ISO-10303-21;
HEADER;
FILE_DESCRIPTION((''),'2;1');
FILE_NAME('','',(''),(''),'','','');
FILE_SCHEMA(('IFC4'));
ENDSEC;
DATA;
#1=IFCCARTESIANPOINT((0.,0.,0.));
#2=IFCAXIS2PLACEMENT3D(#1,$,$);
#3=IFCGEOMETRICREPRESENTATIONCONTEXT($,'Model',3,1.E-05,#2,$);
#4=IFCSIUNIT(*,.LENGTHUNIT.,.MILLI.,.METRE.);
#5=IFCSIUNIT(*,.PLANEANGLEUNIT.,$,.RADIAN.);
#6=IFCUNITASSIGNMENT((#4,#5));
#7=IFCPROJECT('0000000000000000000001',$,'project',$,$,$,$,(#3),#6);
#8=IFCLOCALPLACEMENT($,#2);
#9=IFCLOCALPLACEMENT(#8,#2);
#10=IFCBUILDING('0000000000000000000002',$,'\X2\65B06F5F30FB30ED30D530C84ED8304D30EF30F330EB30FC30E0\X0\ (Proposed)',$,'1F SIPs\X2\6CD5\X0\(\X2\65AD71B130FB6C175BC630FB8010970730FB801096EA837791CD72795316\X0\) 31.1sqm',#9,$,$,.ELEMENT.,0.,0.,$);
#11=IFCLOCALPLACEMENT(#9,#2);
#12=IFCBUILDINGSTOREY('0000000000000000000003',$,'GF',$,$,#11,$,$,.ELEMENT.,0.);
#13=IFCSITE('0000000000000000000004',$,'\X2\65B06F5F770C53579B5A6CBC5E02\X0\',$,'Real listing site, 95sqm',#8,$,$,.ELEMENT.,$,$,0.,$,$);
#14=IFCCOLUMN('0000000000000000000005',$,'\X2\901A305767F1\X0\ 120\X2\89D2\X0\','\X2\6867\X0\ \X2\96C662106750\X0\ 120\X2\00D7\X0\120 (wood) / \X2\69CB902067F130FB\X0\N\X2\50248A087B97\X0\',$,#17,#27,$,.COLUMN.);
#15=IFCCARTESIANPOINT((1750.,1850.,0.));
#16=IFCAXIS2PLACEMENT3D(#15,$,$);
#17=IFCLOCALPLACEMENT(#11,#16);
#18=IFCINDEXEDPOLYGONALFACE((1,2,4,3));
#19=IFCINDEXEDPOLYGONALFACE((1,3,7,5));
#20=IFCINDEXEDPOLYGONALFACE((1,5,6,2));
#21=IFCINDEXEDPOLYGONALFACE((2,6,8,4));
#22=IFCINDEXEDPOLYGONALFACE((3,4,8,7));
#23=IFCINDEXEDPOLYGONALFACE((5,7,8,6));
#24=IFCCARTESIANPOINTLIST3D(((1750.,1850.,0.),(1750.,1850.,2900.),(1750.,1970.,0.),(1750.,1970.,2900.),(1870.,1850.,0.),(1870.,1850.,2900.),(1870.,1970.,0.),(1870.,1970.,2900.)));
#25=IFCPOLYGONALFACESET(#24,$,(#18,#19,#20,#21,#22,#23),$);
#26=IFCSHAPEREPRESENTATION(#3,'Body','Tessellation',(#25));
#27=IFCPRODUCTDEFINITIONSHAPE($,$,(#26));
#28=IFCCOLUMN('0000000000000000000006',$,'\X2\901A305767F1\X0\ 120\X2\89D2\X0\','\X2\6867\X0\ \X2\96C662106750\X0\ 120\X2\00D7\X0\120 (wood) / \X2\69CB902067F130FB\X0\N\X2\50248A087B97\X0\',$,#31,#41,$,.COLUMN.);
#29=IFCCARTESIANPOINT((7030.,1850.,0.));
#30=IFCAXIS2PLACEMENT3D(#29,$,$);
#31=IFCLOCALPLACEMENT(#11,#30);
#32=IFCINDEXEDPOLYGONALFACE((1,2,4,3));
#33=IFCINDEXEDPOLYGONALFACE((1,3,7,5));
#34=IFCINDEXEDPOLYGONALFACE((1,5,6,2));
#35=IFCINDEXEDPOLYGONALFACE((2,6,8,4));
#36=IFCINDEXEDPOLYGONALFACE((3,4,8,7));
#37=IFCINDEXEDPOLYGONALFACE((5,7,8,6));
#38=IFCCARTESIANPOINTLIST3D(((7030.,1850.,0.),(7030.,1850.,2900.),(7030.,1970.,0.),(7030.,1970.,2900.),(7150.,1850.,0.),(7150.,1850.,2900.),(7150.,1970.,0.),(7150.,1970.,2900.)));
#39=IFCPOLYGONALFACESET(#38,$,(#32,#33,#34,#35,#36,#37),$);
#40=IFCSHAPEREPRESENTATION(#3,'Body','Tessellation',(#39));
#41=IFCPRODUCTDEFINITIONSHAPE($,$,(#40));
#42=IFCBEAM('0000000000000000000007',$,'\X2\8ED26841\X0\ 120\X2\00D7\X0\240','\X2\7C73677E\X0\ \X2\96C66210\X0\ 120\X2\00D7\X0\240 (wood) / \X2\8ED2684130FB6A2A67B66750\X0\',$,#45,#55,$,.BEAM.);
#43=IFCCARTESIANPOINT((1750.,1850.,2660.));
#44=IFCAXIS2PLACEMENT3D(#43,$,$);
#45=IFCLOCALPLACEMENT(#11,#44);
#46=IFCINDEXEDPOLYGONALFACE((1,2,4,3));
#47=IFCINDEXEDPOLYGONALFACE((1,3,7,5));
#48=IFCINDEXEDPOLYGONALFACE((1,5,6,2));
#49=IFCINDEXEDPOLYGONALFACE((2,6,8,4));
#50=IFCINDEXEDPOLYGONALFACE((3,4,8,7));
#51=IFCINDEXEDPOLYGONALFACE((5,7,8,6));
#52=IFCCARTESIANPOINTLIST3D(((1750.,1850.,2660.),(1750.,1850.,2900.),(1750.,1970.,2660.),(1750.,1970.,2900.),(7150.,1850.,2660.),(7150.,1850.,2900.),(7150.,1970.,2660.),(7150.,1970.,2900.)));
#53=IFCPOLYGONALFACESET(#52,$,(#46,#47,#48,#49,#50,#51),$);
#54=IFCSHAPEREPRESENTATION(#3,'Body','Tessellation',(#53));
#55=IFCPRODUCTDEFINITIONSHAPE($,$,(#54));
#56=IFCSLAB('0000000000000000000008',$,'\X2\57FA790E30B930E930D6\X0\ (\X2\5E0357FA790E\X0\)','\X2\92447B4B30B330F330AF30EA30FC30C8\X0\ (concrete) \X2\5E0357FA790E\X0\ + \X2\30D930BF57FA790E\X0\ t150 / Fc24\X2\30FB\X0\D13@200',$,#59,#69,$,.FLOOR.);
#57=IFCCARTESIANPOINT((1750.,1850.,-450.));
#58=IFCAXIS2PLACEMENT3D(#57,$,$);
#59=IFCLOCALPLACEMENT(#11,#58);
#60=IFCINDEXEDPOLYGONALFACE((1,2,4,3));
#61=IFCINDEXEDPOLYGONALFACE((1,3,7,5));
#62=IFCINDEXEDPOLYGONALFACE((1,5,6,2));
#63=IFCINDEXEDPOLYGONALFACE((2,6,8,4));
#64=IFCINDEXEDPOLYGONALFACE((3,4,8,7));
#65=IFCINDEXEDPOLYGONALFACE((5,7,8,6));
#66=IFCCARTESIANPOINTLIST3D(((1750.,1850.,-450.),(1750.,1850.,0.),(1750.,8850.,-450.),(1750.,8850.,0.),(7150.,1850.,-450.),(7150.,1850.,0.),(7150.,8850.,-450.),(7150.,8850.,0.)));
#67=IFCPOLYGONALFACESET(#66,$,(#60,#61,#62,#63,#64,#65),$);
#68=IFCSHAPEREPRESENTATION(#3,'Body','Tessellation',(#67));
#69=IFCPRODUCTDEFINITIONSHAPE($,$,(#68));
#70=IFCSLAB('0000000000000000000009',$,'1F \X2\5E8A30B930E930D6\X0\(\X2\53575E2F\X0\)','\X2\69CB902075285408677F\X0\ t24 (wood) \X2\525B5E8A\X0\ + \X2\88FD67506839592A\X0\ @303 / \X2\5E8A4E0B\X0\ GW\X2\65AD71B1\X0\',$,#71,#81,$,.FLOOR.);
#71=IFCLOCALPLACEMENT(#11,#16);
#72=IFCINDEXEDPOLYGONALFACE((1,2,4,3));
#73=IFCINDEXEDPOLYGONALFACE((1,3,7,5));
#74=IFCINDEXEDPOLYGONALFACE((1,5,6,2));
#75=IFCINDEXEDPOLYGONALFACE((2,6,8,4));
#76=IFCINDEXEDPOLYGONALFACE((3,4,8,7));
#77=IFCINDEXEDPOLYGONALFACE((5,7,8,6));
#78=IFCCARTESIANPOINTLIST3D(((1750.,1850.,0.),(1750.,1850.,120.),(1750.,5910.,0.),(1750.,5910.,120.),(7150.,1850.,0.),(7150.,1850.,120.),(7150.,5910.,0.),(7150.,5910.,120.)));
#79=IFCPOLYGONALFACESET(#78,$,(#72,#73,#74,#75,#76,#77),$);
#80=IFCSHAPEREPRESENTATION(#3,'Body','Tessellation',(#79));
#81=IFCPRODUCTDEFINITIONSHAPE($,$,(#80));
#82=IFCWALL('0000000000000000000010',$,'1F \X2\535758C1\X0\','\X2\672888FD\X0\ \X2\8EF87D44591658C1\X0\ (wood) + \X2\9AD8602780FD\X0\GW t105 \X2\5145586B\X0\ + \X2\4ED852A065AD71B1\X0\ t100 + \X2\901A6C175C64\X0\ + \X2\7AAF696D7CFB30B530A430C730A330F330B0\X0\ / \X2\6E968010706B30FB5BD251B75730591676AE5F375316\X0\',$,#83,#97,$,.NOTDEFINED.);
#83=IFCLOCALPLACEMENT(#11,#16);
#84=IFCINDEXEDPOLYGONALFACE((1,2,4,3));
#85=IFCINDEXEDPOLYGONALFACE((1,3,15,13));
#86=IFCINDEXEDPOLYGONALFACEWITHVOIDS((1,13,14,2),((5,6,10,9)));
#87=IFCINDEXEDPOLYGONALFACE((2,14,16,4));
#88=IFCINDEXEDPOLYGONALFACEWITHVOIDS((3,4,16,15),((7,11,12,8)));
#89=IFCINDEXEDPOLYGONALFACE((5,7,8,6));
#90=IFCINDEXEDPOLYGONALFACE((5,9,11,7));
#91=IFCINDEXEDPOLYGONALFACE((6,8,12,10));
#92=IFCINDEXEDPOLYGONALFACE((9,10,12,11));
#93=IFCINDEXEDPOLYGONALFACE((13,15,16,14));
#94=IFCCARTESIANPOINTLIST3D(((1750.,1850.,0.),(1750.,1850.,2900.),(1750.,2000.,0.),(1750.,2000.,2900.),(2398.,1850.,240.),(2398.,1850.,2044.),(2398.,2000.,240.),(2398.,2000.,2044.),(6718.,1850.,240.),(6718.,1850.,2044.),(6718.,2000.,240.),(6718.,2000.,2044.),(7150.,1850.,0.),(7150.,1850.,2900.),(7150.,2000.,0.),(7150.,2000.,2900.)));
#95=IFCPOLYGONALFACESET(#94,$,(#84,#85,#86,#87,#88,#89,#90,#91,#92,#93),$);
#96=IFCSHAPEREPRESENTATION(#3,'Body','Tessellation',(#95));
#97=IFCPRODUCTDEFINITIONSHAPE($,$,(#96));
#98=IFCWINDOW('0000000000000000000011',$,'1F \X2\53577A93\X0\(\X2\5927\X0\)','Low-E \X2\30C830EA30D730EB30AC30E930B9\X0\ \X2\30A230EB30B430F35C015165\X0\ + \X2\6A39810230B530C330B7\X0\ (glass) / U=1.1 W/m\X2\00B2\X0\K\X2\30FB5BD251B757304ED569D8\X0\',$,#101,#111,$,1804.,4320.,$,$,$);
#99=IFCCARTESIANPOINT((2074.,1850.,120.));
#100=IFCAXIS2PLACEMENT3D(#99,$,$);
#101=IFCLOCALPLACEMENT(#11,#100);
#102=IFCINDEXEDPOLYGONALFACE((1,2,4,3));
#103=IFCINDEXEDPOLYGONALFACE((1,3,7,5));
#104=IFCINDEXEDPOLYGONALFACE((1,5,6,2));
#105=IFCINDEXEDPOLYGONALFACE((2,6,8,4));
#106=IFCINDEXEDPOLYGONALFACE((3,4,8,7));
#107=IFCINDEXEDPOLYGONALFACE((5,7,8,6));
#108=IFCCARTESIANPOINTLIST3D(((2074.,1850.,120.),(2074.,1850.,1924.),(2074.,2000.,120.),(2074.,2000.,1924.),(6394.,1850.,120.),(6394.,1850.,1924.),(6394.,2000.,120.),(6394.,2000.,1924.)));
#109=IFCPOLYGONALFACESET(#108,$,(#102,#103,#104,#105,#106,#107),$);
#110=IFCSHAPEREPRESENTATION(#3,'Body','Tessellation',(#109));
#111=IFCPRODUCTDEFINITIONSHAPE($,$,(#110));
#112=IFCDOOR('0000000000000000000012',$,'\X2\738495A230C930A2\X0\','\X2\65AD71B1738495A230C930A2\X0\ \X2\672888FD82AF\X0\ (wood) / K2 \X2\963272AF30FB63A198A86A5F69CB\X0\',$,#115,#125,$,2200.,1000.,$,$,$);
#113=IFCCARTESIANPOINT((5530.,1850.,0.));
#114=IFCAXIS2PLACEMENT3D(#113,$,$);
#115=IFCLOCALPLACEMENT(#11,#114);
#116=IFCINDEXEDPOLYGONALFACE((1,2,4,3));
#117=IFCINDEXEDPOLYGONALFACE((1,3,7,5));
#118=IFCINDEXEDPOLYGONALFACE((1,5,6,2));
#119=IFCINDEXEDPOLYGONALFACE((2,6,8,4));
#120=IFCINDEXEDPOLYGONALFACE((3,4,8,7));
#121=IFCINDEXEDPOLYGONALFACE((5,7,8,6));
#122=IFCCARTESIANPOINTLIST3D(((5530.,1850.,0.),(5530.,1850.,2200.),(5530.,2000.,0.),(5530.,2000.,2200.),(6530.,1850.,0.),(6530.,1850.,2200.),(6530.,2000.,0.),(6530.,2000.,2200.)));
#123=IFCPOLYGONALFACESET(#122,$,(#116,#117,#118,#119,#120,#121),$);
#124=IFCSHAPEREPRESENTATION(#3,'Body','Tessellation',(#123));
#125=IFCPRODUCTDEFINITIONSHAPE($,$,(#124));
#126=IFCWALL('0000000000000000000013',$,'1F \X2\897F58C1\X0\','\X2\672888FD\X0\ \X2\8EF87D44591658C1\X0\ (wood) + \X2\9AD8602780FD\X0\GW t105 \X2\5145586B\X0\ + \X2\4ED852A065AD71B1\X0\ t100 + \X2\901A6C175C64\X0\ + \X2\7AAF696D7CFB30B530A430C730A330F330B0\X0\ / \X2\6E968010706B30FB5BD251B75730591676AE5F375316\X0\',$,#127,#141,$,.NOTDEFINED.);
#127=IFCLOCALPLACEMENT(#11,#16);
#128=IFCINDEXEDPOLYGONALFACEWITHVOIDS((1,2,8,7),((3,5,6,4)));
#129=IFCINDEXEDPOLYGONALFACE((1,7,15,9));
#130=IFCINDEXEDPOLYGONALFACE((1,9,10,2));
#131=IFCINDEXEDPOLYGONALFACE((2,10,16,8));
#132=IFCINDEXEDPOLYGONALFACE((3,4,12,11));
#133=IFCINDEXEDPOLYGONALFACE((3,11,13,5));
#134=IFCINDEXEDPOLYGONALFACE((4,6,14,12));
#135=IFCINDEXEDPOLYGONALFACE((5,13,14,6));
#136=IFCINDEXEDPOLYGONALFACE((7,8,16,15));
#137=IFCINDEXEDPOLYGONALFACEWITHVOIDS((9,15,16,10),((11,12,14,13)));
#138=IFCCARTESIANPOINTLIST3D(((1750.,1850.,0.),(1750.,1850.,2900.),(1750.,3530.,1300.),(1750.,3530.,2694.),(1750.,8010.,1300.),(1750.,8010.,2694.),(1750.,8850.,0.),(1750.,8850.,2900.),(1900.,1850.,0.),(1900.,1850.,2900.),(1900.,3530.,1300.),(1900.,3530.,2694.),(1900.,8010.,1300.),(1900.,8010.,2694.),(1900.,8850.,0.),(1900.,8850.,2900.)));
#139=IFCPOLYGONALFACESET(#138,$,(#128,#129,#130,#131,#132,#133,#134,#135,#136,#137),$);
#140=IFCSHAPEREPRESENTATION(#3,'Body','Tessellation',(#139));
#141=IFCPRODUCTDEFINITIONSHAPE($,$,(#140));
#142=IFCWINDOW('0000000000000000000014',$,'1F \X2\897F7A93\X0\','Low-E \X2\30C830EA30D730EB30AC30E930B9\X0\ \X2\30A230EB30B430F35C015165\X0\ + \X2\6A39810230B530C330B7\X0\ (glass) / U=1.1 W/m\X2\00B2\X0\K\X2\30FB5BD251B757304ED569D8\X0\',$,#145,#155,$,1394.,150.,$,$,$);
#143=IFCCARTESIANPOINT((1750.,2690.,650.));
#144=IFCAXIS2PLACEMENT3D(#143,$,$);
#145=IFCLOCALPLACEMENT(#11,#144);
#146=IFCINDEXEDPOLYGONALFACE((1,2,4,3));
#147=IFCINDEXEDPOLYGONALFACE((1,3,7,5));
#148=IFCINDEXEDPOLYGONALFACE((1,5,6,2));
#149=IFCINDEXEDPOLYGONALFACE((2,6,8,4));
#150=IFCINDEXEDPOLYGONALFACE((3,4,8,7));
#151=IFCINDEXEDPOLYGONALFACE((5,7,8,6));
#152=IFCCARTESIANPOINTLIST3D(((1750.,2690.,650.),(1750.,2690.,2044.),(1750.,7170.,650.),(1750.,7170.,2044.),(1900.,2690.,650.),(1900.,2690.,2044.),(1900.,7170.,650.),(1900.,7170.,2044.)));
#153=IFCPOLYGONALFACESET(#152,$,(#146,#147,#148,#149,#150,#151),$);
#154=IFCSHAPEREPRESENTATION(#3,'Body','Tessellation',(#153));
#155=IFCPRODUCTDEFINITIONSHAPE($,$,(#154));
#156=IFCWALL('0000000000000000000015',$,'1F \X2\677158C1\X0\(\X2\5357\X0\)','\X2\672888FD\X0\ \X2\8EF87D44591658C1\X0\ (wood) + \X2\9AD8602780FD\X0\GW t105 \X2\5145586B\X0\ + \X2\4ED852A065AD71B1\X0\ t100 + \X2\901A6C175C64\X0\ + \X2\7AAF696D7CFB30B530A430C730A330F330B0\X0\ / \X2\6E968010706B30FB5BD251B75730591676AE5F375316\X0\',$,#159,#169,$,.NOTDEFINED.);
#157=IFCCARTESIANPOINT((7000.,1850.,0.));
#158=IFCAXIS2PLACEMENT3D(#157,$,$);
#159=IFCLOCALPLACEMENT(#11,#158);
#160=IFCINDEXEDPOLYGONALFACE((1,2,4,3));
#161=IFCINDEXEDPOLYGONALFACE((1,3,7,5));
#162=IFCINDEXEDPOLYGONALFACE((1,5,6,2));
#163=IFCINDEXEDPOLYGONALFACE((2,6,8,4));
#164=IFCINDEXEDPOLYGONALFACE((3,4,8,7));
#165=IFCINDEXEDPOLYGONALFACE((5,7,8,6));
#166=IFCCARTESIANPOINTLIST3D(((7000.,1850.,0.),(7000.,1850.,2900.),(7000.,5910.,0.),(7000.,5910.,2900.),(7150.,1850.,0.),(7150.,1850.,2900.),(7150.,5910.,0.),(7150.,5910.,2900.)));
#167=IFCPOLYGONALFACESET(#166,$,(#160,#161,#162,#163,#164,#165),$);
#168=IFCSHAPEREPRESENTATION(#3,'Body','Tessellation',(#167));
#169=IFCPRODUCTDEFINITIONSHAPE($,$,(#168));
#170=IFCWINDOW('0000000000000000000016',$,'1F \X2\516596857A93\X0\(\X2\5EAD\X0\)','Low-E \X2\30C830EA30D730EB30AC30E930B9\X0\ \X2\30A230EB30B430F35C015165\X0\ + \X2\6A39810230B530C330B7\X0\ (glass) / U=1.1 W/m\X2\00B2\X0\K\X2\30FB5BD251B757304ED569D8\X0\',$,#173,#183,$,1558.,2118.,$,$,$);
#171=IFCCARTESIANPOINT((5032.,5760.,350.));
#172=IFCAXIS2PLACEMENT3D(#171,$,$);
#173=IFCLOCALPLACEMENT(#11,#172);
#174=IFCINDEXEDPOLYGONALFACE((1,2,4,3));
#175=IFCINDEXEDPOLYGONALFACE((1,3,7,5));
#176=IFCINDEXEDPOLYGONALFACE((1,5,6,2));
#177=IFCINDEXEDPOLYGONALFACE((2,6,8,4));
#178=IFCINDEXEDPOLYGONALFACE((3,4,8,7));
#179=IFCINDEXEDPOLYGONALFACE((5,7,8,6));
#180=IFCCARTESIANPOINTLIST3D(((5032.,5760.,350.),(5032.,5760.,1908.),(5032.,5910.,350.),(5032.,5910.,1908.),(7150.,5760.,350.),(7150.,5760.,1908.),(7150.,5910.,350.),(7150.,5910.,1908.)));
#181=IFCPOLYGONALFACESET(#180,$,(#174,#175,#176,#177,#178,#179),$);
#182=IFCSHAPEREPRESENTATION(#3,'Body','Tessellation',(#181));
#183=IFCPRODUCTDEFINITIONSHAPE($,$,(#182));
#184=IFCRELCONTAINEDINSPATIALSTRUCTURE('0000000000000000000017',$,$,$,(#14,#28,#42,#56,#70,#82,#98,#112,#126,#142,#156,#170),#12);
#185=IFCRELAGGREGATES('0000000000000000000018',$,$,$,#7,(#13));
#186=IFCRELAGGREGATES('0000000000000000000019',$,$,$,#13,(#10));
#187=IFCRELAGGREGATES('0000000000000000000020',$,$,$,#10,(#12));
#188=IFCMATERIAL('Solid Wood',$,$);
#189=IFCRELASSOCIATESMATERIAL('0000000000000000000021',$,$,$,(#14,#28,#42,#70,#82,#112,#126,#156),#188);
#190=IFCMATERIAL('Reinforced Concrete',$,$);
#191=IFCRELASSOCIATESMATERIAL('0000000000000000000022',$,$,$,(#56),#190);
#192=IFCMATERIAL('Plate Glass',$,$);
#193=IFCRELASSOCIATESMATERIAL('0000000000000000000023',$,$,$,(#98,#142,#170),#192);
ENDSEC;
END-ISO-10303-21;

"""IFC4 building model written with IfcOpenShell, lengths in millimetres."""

from ifc_helpers import new_model, si_unit, frame, frame_2d, origin, place, context, project, spatial, rectangle, extrude, material, element, fill, save


model = new_model("IFC4")

# Units and contexts
model_context = context("Model", 3, precision=1e-05, world=origin())
ifc_project = project(units=[si_unit("LENGTHUNIT", "METRE", prefix="MILLI"), si_unit("PLANEANGLEUNIT", "RADIAN")], contexts=[model_context])

# Site, building, storey
site_placement = place(None, origin())
site = spatial("IfcSite", under=ifc_project, at=site_placement, Name="新潟県南魚沼市", ObjectType="Real listing site, 95sqm", CompositionType="ELEMENT", RefElevation=0.0)
building_placement = place(site_placement, origin())
building = spatial("IfcBuilding", under=site, at=building_placement, Name="新潟・ロフト付きワンルーム (Proposed)", ObjectType="1F SIPs法(断熱・気密・耐震・耐雪荷重特化) 31.1sqm", CompositionType="ELEMENT", ElevationOfRefHeight=0.0, ElevationOfTerrain=0.0)
storey_placement = place(building_placement, origin())
storey = spatial("IfcBuildingStorey", under=building, at=storey_placement, Name="GF", CompositionType="ELEMENT", Elevation=0.0)

# Columns
ifc_material_1 = material(Name="Solid Wood")
column_1_placement = place(storey_placement, frame((1750.0, 1850.0, 0.0)))
element("IfcColumn", 1, at=column_1_placement, inside=storey, material=ifc_material_1, Name="通し柱 120角", Description="桧 集成材 120×120 (wood) / 構造柱・N値計算", PredefinedType="COLUMN", context=model_context, shape_type="SweptSolid", body=[
    extrude(rectangle(XDim=120.0, YDim=120.0, at=frame_2d((60.0, 60.0))), frame((1750.0, 1850.0, 0.0)), (0.0, 0.0, 1.0), 2900.0),
])
column_2_placement = place(storey_placement, frame((7030.0, 1850.0, 0.0)))
element("IfcColumn", 2, at=column_2_placement, inside=storey, material=ifc_material_1, Name="通し柱 120角", Description="桧 集成材 120×120 (wood) / 構造柱・N値計算", PredefinedType="COLUMN", context=model_context, shape_type="SweptSolid", body=[
    extrude(rectangle(XDim=120.0, YDim=120.0, at=frame_2d((60.0, 60.0))), frame((7030.0, 1850.0, 0.0)), (0.0, 0.0, 1.0), 2900.0),
])

# Beam
beam_1_placement = place(storey_placement, frame((1750.0, 1850.0, 2660.0)))
element("IfcBeam", 3, at=beam_1_placement, inside=storey, material=ifc_material_1, Name="軒桁 120×240", Description="米松 集成 120×240 (wood) / 軒桁・横架材", PredefinedType="BEAM", context=model_context, shape_type="SweptSolid", body=[
    extrude(rectangle(XDim=5400.0, YDim=120.0, at=frame_2d((2700.0, 60.0))), frame((1750.0, 1850.0, 2660.0)), (0.0, 0.0, 1.0), 240.0),
])

# Slabs
ifc_material_2 = material(Name="Reinforced Concrete")
slab_1_placement = place(storey_placement, frame((1750.0, 1850.0, -450.0)))
element("IfcSlab", 4, at=slab_1_placement, inside=storey, material=ifc_material_2, Name="基礎スラブ (布基礎)", Description="鉄筋コンクリート (concrete) 布基礎 + ベタ基礎 t150 / Fc24・D13@200", PredefinedType="FLOOR", context=model_context, shape_type="SweptSolid", body=[
    extrude(rectangle(XDim=5400.0, YDim=7000.0, at=frame_2d((2700.0, 3500.0))), frame((1750.0, 1850.0, -450.0)), (0.0, 0.0, 1.0), 450.0),
])
slab_2_placement = place(storey_placement, frame((1750.0, 1850.0, 0.0)))
element("IfcSlab", 5, at=slab_2_placement, inside=storey, material=ifc_material_1, Name="1F 床スラブ(南帯)", Description="構造用合板 t24 (wood) 剛床 + 製材根太 @303 / 床下 GW断熱", PredefinedType="FLOOR", context=model_context, shape_type="SweptSolid", body=[
    extrude(rectangle(XDim=5400.0, YDim=4060.0, at=frame_2d((2700.0, 2030.0))), frame((1750.0, 1850.0, 0.0)), (0.0, 0.0, 1.0), 120.0),
])

# Wall, openings, window, door
wall_1_placement = place(storey_placement, frame((1750.0, 1850.0, 0.0)))
wall_1 = element("IfcWall", 6, at=wall_1_placement, inside=storey, material=ifc_material_1, Name="1F 南壁", Description="木製 軸組外壁 (wood) + 高性能GW t105 充填 + 付加断熱 t100 + 通気層 + 窯業系サイディング / 準耐火・寒冷地外皮強化", PredefinedType="NOTDEFINED", context=model_context, shape_type="SweptSolid", body=[
    extrude(rectangle(XDim=5400.0, YDim=150.0, at=frame_2d((2700.0, 75.0))), frame((1750.0, 1850.0, 0.0)), (0.0, 0.0, 1.0), 2900.0),
])
opening_1_placement = place(storey_placement, frame((2074.0, 1850.0, 120.0)))
opening_1 = element("IfcOpeningElement", 7, at=opening_1_placement, cuts=wall_1, PredefinedType="NOTDEFINED", context=model_context, shape_type="SweptSolid", body=[
    extrude(rectangle(XDim=4320.0, YDim=150.0, at=frame_2d((2160.0, 75.0))), frame((2074.0, 1850.0, 120.0)), (0.0, 0.0, 1.0), 1804.0),
])
opening_2_placement = place(storey_placement, frame((5530.0, 1850.0, 0.0)))
opening_2 = element("IfcOpeningElement", 8, at=opening_2_placement, cuts=wall_1, PredefinedType="NOTDEFINED", context=model_context, shape_type="SweptSolid", body=[
    extrude(rectangle(XDim=1000.0, YDim=150.0, at=frame_2d((500.0, 75.0))), frame((5530.0, 1850.0, 0.0)), (0.0, 0.0, 1.0), 2200.0),
])
ifc_material_3 = material(Name="Plate Glass")
window_1_placement = place(storey_placement, frame((2074.0, 1850.0, 120.0)))
window_1 = element("IfcWindow", 9, at=window_1_placement, inside=storey, material=ifc_material_3, Name="1F 南窓(大)", Description="Low-E トリプルガラス アルゴン封入 + 樹脂サッシ (glass) / U=1.1 W/m²K・寒冷地仕様", OverallHeight=1804.0, OverallWidth=4320.0, context=model_context, shape_type="SweptSolid", body=[
    extrude(rectangle(XDim=4320.0, YDim=150.0, at=frame_2d((2160.0, 75.0))), frame((2074.0, 1850.0, 120.0)), (0.0, 0.0, 1.0), 1804.0),
])
fill(opening_1, window_1)
door_1_placement = place(storey_placement, frame((5530.0, 1850.0, 0.0)))
door_1 = element("IfcDoor", 10, at=door_1_placement, inside=storey, material=ifc_material_1, Name="玄関ドア", Description="断熱玄関ドア 木製芯 (wood) / K2 防犯・採風機構", OverallHeight=2200.0, OverallWidth=1000.0, context=model_context, shape_type="SweptSolid", body=[
    extrude(rectangle(XDim=1000.0, YDim=150.0, at=frame_2d((500.0, 75.0))), frame((5530.0, 1850.0, 0.0)), (0.0, 0.0, 1.0), 2200.0),
])
fill(opening_2, door_1)

# Walls, openings, windows
wall_2_placement = place(storey_placement, frame((1750.0, 1850.0, 0.0)))
wall_2 = element("IfcWall", 11, at=wall_2_placement, inside=storey, material=ifc_material_1, Name="1F 西壁", Description="木製 軸組外壁 (wood) + 高性能GW t105 充填 + 付加断熱 t100 + 通気層 + 窯業系サイディング / 準耐火・寒冷地外皮強化", PredefinedType="NOTDEFINED", context=model_context, shape_type="SweptSolid", body=[
    extrude(rectangle(XDim=150.0, YDim=7000.0, at=frame_2d((75.0, 3500.0))), frame((1750.0, 1850.0, 0.0)), (0.0, 0.0, 1.0), 2900.0),
])
opening_3_placement = place(storey_placement, frame((1750.0, 2690.0, 650.0)))
opening_3 = element("IfcOpeningElement", 12, at=opening_3_placement, cuts=wall_2, PredefinedType="NOTDEFINED", context=model_context, shape_type="SweptSolid", body=[
    extrude(rectangle(XDim=150.0, YDim=4480.0, at=frame_2d((75.0, 2240.0))), frame((1750.0, 2690.0, 650.0)), (0.0, 0.0, 1.0), 1394.0),
])
window_2_placement = place(storey_placement, frame((1750.0, 2690.0, 650.0)))
window_2 = element("IfcWindow", 13, at=window_2_placement, inside=storey, material=ifc_material_3, Name="1F 西窓", Description="Low-E トリプルガラス アルゴン封入 + 樹脂サッシ (glass) / U=1.1 W/m²K・寒冷地仕様", OverallHeight=1394.0, OverallWidth=150.0, context=model_context, shape_type="SweptSolid", body=[
    extrude(rectangle(XDim=150.0, YDim=4480.0, at=frame_2d((75.0, 2240.0))), frame((1750.0, 2690.0, 650.0)), (0.0, 0.0, 1.0), 1394.0),
])
fill(opening_3, window_2)
wall_3_placement = place(storey_placement, frame((7000.0, 1850.0, 0.0)))
wall_3 = element("IfcWall", 14, at=wall_3_placement, inside=storey, material=ifc_material_1, Name="1F 東壁(南)", Description="木製 軸組外壁 (wood) + 高性能GW t105 充填 + 付加断熱 t100 + 通気層 + 窯業系サイディング / 準耐火・寒冷地外皮強化", PredefinedType="NOTDEFINED", context=model_context, shape_type="SweptSolid", body=[
    extrude(rectangle(XDim=150.0, YDim=4060.0, at=frame_2d((75.0, 2030.0))), frame((7000.0, 1850.0, 0.0)), (0.0, 0.0, 1.0), 2900.0),
])
opening_4_placement = place(storey_placement, frame((5032.0, 5760.0, 350.0)))
opening_4 = element("IfcOpeningElement", 15, at=opening_4_placement, cuts=wall_3, PredefinedType="NOTDEFINED", context=model_context, shape_type="SweptSolid", body=[
    extrude(rectangle(XDim=2118.0, YDim=150.0, at=frame_2d((1059.0, 75.0))), frame((5032.0, 5760.0, 350.0)), (0.0, 0.0, 1.0), 1558.0),
])
window_3_placement = place(storey_placement, frame((5032.0, 5760.0, 350.0)))
window_3 = element("IfcWindow", 16, at=window_3_placement, inside=storey, material=ifc_material_3, Name="1F 入隅窓(庭)", Description="Low-E トリプルガラス アルゴン封入 + 樹脂サッシ (glass) / U=1.1 W/m²K・寒冷地仕様", OverallHeight=1558.0, OverallWidth=2118.0, context=model_context, shape_type="SweptSolid", body=[
    extrude(rectangle(XDim=2118.0, YDim=150.0, at=frame_2d((1059.0, 75.0))), frame((5032.0, 5760.0, 350.0)), (0.0, 0.0, 1.0), 1558.0),
])
fill(opening_4, window_3)

save(model, "model.ifc")
